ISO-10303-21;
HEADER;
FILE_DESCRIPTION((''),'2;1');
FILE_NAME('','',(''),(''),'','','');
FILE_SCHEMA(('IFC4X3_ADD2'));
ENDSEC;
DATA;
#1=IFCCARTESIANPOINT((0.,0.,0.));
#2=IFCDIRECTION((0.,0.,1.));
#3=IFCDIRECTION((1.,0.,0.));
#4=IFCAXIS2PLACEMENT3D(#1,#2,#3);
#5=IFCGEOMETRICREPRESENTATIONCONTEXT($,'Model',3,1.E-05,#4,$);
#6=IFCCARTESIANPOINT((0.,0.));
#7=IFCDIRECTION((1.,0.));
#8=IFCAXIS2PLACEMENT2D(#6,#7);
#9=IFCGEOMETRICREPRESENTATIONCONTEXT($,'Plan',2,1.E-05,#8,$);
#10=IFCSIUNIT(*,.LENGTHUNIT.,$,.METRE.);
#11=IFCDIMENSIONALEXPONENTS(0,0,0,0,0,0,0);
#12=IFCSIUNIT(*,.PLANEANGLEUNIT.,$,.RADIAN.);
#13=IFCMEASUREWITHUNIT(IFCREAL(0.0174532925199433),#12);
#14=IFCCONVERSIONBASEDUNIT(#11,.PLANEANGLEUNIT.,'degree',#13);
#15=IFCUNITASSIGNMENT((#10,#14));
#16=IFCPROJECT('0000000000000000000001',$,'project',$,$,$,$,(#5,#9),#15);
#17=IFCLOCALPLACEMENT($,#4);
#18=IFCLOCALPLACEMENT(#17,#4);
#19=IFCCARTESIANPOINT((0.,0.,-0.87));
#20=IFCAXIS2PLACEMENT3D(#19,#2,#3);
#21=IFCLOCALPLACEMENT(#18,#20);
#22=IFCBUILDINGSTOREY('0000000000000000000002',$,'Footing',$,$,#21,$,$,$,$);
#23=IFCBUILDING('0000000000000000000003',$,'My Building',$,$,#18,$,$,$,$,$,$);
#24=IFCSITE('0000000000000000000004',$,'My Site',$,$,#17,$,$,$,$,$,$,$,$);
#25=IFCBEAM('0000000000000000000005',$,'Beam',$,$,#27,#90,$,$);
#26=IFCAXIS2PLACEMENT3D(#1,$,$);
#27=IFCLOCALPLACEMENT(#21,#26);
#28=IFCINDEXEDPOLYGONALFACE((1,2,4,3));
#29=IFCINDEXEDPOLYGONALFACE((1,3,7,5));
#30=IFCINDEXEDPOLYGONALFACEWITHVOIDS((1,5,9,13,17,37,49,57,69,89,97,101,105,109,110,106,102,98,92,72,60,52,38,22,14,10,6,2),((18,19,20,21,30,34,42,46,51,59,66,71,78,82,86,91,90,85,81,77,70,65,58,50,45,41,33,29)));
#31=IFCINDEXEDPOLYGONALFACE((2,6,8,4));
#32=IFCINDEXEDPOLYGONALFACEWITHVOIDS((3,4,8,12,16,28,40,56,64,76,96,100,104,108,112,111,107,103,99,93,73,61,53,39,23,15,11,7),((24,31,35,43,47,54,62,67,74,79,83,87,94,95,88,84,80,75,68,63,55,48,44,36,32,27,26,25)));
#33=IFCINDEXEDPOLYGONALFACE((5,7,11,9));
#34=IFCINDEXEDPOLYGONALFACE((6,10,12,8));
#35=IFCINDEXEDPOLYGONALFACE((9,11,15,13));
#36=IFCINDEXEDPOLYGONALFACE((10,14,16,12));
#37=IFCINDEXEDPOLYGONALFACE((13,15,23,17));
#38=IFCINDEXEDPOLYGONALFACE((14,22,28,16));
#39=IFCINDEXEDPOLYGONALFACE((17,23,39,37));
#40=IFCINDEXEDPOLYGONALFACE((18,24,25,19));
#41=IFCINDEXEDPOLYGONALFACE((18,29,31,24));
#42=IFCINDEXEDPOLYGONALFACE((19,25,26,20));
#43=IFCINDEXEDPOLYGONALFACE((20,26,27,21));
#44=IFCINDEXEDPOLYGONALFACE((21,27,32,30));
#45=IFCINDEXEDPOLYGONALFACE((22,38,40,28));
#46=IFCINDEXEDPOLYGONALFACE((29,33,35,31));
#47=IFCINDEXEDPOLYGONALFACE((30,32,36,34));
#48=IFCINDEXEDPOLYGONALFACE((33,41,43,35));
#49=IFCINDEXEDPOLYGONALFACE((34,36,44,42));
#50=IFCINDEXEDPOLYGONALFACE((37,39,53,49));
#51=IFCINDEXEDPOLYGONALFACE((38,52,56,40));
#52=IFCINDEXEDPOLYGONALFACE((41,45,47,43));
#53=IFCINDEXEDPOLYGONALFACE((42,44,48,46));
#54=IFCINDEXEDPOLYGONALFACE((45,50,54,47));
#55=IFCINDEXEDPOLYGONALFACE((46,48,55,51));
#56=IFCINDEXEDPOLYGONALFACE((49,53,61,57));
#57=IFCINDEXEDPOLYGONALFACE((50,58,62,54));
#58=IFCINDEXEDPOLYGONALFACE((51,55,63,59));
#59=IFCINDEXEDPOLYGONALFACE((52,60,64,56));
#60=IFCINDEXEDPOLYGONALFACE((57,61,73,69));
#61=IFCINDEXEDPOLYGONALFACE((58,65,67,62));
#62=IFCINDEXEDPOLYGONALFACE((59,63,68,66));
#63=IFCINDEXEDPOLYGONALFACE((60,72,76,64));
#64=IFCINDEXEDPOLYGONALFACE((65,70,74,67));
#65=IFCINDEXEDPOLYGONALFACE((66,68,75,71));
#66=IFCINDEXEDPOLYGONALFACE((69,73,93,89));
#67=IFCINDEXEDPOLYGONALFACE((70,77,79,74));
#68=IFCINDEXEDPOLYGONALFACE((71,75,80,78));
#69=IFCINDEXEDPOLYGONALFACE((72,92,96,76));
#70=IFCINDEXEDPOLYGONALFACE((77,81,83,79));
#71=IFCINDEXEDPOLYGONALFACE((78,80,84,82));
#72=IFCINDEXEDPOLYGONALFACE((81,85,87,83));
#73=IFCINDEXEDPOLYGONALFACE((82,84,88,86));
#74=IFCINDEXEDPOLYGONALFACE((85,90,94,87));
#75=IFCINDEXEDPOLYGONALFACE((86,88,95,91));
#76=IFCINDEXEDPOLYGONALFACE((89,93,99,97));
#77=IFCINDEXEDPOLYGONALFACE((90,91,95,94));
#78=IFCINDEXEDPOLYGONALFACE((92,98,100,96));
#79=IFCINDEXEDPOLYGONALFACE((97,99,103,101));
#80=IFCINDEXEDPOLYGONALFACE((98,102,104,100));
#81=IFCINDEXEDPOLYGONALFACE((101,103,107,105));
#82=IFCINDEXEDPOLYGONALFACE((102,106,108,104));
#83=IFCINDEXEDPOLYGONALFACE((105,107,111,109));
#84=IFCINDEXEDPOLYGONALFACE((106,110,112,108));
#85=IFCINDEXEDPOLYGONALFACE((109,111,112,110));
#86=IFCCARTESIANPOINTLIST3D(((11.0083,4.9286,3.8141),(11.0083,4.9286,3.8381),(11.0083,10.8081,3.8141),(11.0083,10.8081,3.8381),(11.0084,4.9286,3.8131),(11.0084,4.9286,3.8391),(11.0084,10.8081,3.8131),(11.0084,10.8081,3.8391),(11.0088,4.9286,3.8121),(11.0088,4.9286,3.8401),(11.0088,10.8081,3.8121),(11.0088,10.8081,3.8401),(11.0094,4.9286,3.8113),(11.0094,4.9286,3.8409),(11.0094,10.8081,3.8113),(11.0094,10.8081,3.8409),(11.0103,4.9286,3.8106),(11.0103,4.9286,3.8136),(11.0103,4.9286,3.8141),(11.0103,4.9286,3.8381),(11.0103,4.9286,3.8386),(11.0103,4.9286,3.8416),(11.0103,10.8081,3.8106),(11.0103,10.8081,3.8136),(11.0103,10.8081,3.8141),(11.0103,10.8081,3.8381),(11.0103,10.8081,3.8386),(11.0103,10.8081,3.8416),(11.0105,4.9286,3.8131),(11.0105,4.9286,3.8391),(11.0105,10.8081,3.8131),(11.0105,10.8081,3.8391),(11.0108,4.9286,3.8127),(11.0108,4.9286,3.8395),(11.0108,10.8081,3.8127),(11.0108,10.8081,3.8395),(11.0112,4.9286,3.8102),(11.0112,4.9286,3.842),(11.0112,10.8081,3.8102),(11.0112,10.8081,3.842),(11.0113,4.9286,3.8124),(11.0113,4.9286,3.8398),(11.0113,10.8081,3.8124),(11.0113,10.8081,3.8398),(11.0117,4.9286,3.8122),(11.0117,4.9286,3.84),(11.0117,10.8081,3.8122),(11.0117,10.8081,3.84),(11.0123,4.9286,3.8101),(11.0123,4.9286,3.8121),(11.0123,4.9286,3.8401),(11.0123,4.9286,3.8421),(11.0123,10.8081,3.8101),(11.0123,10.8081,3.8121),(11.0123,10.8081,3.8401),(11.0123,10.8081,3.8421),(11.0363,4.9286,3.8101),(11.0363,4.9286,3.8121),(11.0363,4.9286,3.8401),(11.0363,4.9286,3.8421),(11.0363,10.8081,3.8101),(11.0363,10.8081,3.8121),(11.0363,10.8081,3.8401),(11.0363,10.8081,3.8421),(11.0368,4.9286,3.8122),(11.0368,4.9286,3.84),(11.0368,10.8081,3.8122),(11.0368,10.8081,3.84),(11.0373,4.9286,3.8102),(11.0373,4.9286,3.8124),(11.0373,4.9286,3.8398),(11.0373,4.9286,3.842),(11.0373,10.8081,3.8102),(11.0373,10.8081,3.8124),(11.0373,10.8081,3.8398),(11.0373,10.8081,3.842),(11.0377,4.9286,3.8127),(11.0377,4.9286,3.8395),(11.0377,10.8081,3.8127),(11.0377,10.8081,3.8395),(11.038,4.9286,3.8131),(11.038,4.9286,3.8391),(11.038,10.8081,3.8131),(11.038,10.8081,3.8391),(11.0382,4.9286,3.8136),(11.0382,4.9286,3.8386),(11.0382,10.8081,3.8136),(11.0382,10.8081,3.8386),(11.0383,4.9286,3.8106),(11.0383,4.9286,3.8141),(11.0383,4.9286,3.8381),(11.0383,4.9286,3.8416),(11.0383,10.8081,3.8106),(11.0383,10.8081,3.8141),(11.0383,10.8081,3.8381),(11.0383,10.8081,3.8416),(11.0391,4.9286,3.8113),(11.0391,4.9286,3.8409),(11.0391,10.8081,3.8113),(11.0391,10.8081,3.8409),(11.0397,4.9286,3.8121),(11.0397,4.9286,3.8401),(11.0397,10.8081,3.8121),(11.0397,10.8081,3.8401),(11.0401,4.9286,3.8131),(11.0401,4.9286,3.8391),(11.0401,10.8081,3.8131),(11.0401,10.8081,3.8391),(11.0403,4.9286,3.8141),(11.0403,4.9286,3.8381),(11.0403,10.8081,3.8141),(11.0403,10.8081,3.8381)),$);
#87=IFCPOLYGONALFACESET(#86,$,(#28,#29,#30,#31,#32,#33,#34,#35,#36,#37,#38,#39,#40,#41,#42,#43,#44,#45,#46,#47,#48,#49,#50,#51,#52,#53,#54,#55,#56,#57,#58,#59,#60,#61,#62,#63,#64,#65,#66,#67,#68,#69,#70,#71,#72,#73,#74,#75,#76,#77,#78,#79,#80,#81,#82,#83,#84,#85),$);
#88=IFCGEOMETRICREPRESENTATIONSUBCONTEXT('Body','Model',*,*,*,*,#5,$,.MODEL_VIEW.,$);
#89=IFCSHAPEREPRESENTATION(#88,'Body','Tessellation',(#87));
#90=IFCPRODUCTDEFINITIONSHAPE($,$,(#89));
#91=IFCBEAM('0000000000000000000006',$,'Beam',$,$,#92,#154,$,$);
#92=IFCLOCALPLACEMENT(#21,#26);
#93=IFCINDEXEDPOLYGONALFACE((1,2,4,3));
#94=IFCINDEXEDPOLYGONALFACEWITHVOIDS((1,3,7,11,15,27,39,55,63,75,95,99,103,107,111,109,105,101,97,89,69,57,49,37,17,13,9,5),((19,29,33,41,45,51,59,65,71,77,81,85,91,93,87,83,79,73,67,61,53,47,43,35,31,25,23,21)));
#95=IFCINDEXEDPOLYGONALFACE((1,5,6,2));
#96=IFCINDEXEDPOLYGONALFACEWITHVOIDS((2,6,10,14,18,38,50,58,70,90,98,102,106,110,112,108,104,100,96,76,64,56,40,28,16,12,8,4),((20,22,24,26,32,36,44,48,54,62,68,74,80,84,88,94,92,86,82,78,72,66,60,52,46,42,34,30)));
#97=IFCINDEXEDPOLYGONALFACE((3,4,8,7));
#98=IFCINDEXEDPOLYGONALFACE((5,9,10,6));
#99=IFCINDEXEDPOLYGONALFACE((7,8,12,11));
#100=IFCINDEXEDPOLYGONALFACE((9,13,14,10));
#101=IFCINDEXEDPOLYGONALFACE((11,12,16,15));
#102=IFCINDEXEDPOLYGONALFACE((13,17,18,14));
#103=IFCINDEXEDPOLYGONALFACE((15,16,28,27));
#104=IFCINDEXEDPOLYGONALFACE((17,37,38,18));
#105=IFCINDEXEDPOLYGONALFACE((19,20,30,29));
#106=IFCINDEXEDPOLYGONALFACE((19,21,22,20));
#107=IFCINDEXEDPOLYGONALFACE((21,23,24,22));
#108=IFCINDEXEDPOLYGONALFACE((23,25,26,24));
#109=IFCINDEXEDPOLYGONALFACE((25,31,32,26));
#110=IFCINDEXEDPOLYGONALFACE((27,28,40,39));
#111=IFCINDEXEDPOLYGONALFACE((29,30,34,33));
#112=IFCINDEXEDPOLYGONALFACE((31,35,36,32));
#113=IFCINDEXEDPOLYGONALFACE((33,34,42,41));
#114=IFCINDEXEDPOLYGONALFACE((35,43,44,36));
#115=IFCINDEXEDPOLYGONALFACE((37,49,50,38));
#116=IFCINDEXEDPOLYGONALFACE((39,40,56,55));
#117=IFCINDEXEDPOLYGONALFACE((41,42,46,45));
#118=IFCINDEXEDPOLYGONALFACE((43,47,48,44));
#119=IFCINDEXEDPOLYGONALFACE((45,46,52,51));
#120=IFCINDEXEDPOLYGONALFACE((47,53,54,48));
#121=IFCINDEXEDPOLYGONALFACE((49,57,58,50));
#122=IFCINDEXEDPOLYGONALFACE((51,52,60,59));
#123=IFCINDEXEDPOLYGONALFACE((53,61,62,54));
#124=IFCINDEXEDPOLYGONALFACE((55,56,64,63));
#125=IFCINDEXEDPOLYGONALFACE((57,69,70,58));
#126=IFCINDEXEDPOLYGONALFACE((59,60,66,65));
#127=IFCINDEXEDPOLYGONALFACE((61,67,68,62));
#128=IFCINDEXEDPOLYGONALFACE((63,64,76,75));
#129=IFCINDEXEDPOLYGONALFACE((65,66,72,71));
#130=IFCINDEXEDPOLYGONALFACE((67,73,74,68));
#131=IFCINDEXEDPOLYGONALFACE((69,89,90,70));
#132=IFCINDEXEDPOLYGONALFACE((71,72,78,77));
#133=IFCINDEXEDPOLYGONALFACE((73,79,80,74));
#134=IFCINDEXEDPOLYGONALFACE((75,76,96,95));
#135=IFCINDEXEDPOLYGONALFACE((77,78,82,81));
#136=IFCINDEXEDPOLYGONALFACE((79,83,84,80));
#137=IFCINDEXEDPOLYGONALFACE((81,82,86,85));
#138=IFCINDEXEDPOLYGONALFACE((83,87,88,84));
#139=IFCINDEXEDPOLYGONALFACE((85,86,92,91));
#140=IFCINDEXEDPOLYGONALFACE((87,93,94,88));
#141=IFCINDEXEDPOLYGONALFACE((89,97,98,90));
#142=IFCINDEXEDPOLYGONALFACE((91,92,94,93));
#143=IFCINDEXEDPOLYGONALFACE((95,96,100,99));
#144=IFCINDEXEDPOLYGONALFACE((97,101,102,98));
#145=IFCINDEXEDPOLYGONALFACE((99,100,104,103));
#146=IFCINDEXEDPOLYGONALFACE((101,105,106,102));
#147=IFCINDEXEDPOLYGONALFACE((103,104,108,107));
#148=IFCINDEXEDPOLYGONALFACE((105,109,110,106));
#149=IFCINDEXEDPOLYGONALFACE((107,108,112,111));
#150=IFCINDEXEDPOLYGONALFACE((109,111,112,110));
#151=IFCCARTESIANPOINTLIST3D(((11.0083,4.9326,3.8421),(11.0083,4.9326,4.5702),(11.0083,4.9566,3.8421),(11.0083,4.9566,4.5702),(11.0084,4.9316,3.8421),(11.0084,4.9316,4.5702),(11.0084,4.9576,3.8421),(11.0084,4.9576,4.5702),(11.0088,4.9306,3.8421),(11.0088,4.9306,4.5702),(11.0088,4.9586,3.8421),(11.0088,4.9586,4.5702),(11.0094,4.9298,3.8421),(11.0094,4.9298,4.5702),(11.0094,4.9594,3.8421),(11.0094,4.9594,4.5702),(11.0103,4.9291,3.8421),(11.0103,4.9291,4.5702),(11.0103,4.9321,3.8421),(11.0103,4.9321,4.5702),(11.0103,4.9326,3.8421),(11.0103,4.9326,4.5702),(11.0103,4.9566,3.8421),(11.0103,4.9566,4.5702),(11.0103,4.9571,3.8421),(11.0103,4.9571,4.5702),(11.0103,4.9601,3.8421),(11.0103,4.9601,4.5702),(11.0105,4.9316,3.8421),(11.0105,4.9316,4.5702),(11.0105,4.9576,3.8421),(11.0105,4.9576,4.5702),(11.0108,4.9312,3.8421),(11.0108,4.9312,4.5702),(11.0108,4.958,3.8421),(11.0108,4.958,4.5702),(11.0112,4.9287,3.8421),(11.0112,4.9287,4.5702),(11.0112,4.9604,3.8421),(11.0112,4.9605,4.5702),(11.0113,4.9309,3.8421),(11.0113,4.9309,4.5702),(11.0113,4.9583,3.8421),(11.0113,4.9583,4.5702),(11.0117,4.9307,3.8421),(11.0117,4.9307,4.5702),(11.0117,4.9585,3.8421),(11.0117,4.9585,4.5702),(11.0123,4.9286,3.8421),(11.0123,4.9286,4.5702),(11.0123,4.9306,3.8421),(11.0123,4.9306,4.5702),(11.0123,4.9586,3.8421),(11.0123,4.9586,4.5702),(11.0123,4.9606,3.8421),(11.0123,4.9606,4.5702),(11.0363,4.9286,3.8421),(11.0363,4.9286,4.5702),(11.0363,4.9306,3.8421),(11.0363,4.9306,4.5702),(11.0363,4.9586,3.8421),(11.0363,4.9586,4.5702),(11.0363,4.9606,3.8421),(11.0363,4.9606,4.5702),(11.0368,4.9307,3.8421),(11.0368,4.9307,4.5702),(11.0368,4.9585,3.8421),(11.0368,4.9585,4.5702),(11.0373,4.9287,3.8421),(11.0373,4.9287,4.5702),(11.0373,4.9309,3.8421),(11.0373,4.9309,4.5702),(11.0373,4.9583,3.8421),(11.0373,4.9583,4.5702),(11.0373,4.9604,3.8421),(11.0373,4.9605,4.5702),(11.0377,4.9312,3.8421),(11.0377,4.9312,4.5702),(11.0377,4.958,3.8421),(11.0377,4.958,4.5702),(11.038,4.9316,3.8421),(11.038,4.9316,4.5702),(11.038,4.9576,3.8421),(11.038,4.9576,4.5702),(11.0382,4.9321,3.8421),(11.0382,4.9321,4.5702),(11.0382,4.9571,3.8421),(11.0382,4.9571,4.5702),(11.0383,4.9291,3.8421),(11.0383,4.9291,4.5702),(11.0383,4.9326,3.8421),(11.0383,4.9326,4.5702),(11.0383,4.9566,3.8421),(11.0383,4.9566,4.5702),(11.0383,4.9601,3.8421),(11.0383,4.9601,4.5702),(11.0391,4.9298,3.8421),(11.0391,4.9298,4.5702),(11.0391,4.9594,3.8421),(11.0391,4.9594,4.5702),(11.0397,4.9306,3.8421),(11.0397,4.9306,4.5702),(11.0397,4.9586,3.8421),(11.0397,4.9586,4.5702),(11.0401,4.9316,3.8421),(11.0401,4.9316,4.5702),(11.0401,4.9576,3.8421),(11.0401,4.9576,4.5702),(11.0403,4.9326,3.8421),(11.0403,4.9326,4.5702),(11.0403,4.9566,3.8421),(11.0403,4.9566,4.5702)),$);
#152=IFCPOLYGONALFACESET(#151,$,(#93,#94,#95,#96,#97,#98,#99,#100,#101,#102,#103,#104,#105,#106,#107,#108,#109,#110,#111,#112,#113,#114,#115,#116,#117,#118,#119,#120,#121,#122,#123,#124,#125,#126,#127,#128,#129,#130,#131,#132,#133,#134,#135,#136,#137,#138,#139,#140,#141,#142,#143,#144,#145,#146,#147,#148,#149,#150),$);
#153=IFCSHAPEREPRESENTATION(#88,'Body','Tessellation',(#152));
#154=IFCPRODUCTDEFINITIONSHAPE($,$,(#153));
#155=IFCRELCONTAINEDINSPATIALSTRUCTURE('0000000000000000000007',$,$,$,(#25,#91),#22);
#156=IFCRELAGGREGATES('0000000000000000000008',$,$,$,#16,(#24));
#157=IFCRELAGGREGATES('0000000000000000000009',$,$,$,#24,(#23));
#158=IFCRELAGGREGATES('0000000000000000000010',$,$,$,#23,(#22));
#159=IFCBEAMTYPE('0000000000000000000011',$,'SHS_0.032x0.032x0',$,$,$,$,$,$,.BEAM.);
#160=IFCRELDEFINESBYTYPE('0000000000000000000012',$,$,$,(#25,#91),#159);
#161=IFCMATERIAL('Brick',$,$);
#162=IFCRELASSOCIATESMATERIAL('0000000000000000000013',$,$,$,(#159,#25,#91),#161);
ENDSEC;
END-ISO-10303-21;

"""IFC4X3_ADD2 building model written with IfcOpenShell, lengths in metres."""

from ifc_helpers import new_model, entity, si_unit, converted_unit, frame, origin_with_axes, origin_2d_with_axis, place, context, subcontext, project, spatial, hollow_rectangle, extrude, material, material_profile, profile_set, profile_usage, type_object, element, save


model = new_model("IFC4X3_ADD2")

# Units and contexts
model_context = context("Model", 3, precision=1e-05, world=origin_with_axes())
plan_context = context("Plan", 2, precision=1e-05, world=origin_2d_with_axis())
body_context = subcontext(model_context, "Body", "Model", "MODEL_VIEW")
ifc_project = project(units=[si_unit("LENGTHUNIT", "METRE"), converted_unit("PLANEANGLEUNIT", "degree", entity("IfcReal", 0.0174532925199433), si_unit("PLANEANGLEUNIT", "RADIAN"), dimensions=[0, 0, 0, 0, 0, 0, 0])], contexts=[model_context, plan_context])

# Site, building, storey
site_placement = place(None, origin_with_axes())
site = spatial("IfcSite", under=ifc_project, at=site_placement, Name="My Site")
building_placement = place(site_placement, origin_with_axes())
building = spatial("IfcBuilding", under=site, at=building_placement, Name="My Building")
storey_placement = place(building_placement, frame((0.0, 0.0, -0.87), z_axis=(0.0, 0.0, 1.0), x_axis=(1.0, 0.0, 0.0)))
storey = spatial("IfcBuildingStorey", under=building, at=storey_placement, Name="Footing")

# Beams
ifc_material_1 = material(Name="Brick")
ifc_material_profile = material_profile(ifc_material_1, hollow_rectangle(XDim=0.032, YDim=0.032, WallThickness=0.002, InnerFilletRadius=0.002, OuterFilletRadius=0.004))
ifc_profile_set = profile_set([ifc_material_profile])
beam_type_1 = type_object("IfcBeamType", Name="SHS_0.032x0.032x0", PredefinedType="BEAM", material=ifc_profile_set)
ifc_profile_usage_1 = profile_usage(ifc_profile_set, cardinal=5)
beam_1_placement = place(storey_placement, frame((11.0243, 4.9286, 3.8261), z_axis=(0.0, 1.0, 0.0), x_axis=(-1.0, 0.0, 0.0)))
element("IfcBeam", 1, at=beam_1_placement, inside=storey, type_object=beam_type_1, material=ifc_profile_usage_1, Name="Beam", context=body_context, shape_type="SweptSolid", body=[
    extrude(hollow_rectangle(XDim=0.032, YDim=0.032, WallThickness=0.002, InnerFilletRadius=0.002, OuterFilletRadius=0.004), origin_with_axes(), (0.0, 0.0, 1.0), 5.8795),
])
ifc_profile_usage_2 = profile_usage(ifc_profile_set, cardinal=5)
beam_2_placement = place(storey_placement, frame((11.0243, 4.9446, 3.8421), z_axis=(0.0, 0.0, 1.0), x_axis=(1.0, 0.0, 0.0)))
element("IfcBeam", 2, at=beam_2_placement, inside=storey, type_object=beam_type_1, material=ifc_profile_usage_2, Name="Beam", context=body_context, shape_type="SweptSolid", body=[
    extrude(hollow_rectangle(XDim=0.032, YDim=0.032, WallThickness=0.002, InnerFilletRadius=0.002, OuterFilletRadius=0.004), origin_with_axes(), (0.0, 0.0, 1.0), 0.7281),
])

save(model, "model.ifc")
